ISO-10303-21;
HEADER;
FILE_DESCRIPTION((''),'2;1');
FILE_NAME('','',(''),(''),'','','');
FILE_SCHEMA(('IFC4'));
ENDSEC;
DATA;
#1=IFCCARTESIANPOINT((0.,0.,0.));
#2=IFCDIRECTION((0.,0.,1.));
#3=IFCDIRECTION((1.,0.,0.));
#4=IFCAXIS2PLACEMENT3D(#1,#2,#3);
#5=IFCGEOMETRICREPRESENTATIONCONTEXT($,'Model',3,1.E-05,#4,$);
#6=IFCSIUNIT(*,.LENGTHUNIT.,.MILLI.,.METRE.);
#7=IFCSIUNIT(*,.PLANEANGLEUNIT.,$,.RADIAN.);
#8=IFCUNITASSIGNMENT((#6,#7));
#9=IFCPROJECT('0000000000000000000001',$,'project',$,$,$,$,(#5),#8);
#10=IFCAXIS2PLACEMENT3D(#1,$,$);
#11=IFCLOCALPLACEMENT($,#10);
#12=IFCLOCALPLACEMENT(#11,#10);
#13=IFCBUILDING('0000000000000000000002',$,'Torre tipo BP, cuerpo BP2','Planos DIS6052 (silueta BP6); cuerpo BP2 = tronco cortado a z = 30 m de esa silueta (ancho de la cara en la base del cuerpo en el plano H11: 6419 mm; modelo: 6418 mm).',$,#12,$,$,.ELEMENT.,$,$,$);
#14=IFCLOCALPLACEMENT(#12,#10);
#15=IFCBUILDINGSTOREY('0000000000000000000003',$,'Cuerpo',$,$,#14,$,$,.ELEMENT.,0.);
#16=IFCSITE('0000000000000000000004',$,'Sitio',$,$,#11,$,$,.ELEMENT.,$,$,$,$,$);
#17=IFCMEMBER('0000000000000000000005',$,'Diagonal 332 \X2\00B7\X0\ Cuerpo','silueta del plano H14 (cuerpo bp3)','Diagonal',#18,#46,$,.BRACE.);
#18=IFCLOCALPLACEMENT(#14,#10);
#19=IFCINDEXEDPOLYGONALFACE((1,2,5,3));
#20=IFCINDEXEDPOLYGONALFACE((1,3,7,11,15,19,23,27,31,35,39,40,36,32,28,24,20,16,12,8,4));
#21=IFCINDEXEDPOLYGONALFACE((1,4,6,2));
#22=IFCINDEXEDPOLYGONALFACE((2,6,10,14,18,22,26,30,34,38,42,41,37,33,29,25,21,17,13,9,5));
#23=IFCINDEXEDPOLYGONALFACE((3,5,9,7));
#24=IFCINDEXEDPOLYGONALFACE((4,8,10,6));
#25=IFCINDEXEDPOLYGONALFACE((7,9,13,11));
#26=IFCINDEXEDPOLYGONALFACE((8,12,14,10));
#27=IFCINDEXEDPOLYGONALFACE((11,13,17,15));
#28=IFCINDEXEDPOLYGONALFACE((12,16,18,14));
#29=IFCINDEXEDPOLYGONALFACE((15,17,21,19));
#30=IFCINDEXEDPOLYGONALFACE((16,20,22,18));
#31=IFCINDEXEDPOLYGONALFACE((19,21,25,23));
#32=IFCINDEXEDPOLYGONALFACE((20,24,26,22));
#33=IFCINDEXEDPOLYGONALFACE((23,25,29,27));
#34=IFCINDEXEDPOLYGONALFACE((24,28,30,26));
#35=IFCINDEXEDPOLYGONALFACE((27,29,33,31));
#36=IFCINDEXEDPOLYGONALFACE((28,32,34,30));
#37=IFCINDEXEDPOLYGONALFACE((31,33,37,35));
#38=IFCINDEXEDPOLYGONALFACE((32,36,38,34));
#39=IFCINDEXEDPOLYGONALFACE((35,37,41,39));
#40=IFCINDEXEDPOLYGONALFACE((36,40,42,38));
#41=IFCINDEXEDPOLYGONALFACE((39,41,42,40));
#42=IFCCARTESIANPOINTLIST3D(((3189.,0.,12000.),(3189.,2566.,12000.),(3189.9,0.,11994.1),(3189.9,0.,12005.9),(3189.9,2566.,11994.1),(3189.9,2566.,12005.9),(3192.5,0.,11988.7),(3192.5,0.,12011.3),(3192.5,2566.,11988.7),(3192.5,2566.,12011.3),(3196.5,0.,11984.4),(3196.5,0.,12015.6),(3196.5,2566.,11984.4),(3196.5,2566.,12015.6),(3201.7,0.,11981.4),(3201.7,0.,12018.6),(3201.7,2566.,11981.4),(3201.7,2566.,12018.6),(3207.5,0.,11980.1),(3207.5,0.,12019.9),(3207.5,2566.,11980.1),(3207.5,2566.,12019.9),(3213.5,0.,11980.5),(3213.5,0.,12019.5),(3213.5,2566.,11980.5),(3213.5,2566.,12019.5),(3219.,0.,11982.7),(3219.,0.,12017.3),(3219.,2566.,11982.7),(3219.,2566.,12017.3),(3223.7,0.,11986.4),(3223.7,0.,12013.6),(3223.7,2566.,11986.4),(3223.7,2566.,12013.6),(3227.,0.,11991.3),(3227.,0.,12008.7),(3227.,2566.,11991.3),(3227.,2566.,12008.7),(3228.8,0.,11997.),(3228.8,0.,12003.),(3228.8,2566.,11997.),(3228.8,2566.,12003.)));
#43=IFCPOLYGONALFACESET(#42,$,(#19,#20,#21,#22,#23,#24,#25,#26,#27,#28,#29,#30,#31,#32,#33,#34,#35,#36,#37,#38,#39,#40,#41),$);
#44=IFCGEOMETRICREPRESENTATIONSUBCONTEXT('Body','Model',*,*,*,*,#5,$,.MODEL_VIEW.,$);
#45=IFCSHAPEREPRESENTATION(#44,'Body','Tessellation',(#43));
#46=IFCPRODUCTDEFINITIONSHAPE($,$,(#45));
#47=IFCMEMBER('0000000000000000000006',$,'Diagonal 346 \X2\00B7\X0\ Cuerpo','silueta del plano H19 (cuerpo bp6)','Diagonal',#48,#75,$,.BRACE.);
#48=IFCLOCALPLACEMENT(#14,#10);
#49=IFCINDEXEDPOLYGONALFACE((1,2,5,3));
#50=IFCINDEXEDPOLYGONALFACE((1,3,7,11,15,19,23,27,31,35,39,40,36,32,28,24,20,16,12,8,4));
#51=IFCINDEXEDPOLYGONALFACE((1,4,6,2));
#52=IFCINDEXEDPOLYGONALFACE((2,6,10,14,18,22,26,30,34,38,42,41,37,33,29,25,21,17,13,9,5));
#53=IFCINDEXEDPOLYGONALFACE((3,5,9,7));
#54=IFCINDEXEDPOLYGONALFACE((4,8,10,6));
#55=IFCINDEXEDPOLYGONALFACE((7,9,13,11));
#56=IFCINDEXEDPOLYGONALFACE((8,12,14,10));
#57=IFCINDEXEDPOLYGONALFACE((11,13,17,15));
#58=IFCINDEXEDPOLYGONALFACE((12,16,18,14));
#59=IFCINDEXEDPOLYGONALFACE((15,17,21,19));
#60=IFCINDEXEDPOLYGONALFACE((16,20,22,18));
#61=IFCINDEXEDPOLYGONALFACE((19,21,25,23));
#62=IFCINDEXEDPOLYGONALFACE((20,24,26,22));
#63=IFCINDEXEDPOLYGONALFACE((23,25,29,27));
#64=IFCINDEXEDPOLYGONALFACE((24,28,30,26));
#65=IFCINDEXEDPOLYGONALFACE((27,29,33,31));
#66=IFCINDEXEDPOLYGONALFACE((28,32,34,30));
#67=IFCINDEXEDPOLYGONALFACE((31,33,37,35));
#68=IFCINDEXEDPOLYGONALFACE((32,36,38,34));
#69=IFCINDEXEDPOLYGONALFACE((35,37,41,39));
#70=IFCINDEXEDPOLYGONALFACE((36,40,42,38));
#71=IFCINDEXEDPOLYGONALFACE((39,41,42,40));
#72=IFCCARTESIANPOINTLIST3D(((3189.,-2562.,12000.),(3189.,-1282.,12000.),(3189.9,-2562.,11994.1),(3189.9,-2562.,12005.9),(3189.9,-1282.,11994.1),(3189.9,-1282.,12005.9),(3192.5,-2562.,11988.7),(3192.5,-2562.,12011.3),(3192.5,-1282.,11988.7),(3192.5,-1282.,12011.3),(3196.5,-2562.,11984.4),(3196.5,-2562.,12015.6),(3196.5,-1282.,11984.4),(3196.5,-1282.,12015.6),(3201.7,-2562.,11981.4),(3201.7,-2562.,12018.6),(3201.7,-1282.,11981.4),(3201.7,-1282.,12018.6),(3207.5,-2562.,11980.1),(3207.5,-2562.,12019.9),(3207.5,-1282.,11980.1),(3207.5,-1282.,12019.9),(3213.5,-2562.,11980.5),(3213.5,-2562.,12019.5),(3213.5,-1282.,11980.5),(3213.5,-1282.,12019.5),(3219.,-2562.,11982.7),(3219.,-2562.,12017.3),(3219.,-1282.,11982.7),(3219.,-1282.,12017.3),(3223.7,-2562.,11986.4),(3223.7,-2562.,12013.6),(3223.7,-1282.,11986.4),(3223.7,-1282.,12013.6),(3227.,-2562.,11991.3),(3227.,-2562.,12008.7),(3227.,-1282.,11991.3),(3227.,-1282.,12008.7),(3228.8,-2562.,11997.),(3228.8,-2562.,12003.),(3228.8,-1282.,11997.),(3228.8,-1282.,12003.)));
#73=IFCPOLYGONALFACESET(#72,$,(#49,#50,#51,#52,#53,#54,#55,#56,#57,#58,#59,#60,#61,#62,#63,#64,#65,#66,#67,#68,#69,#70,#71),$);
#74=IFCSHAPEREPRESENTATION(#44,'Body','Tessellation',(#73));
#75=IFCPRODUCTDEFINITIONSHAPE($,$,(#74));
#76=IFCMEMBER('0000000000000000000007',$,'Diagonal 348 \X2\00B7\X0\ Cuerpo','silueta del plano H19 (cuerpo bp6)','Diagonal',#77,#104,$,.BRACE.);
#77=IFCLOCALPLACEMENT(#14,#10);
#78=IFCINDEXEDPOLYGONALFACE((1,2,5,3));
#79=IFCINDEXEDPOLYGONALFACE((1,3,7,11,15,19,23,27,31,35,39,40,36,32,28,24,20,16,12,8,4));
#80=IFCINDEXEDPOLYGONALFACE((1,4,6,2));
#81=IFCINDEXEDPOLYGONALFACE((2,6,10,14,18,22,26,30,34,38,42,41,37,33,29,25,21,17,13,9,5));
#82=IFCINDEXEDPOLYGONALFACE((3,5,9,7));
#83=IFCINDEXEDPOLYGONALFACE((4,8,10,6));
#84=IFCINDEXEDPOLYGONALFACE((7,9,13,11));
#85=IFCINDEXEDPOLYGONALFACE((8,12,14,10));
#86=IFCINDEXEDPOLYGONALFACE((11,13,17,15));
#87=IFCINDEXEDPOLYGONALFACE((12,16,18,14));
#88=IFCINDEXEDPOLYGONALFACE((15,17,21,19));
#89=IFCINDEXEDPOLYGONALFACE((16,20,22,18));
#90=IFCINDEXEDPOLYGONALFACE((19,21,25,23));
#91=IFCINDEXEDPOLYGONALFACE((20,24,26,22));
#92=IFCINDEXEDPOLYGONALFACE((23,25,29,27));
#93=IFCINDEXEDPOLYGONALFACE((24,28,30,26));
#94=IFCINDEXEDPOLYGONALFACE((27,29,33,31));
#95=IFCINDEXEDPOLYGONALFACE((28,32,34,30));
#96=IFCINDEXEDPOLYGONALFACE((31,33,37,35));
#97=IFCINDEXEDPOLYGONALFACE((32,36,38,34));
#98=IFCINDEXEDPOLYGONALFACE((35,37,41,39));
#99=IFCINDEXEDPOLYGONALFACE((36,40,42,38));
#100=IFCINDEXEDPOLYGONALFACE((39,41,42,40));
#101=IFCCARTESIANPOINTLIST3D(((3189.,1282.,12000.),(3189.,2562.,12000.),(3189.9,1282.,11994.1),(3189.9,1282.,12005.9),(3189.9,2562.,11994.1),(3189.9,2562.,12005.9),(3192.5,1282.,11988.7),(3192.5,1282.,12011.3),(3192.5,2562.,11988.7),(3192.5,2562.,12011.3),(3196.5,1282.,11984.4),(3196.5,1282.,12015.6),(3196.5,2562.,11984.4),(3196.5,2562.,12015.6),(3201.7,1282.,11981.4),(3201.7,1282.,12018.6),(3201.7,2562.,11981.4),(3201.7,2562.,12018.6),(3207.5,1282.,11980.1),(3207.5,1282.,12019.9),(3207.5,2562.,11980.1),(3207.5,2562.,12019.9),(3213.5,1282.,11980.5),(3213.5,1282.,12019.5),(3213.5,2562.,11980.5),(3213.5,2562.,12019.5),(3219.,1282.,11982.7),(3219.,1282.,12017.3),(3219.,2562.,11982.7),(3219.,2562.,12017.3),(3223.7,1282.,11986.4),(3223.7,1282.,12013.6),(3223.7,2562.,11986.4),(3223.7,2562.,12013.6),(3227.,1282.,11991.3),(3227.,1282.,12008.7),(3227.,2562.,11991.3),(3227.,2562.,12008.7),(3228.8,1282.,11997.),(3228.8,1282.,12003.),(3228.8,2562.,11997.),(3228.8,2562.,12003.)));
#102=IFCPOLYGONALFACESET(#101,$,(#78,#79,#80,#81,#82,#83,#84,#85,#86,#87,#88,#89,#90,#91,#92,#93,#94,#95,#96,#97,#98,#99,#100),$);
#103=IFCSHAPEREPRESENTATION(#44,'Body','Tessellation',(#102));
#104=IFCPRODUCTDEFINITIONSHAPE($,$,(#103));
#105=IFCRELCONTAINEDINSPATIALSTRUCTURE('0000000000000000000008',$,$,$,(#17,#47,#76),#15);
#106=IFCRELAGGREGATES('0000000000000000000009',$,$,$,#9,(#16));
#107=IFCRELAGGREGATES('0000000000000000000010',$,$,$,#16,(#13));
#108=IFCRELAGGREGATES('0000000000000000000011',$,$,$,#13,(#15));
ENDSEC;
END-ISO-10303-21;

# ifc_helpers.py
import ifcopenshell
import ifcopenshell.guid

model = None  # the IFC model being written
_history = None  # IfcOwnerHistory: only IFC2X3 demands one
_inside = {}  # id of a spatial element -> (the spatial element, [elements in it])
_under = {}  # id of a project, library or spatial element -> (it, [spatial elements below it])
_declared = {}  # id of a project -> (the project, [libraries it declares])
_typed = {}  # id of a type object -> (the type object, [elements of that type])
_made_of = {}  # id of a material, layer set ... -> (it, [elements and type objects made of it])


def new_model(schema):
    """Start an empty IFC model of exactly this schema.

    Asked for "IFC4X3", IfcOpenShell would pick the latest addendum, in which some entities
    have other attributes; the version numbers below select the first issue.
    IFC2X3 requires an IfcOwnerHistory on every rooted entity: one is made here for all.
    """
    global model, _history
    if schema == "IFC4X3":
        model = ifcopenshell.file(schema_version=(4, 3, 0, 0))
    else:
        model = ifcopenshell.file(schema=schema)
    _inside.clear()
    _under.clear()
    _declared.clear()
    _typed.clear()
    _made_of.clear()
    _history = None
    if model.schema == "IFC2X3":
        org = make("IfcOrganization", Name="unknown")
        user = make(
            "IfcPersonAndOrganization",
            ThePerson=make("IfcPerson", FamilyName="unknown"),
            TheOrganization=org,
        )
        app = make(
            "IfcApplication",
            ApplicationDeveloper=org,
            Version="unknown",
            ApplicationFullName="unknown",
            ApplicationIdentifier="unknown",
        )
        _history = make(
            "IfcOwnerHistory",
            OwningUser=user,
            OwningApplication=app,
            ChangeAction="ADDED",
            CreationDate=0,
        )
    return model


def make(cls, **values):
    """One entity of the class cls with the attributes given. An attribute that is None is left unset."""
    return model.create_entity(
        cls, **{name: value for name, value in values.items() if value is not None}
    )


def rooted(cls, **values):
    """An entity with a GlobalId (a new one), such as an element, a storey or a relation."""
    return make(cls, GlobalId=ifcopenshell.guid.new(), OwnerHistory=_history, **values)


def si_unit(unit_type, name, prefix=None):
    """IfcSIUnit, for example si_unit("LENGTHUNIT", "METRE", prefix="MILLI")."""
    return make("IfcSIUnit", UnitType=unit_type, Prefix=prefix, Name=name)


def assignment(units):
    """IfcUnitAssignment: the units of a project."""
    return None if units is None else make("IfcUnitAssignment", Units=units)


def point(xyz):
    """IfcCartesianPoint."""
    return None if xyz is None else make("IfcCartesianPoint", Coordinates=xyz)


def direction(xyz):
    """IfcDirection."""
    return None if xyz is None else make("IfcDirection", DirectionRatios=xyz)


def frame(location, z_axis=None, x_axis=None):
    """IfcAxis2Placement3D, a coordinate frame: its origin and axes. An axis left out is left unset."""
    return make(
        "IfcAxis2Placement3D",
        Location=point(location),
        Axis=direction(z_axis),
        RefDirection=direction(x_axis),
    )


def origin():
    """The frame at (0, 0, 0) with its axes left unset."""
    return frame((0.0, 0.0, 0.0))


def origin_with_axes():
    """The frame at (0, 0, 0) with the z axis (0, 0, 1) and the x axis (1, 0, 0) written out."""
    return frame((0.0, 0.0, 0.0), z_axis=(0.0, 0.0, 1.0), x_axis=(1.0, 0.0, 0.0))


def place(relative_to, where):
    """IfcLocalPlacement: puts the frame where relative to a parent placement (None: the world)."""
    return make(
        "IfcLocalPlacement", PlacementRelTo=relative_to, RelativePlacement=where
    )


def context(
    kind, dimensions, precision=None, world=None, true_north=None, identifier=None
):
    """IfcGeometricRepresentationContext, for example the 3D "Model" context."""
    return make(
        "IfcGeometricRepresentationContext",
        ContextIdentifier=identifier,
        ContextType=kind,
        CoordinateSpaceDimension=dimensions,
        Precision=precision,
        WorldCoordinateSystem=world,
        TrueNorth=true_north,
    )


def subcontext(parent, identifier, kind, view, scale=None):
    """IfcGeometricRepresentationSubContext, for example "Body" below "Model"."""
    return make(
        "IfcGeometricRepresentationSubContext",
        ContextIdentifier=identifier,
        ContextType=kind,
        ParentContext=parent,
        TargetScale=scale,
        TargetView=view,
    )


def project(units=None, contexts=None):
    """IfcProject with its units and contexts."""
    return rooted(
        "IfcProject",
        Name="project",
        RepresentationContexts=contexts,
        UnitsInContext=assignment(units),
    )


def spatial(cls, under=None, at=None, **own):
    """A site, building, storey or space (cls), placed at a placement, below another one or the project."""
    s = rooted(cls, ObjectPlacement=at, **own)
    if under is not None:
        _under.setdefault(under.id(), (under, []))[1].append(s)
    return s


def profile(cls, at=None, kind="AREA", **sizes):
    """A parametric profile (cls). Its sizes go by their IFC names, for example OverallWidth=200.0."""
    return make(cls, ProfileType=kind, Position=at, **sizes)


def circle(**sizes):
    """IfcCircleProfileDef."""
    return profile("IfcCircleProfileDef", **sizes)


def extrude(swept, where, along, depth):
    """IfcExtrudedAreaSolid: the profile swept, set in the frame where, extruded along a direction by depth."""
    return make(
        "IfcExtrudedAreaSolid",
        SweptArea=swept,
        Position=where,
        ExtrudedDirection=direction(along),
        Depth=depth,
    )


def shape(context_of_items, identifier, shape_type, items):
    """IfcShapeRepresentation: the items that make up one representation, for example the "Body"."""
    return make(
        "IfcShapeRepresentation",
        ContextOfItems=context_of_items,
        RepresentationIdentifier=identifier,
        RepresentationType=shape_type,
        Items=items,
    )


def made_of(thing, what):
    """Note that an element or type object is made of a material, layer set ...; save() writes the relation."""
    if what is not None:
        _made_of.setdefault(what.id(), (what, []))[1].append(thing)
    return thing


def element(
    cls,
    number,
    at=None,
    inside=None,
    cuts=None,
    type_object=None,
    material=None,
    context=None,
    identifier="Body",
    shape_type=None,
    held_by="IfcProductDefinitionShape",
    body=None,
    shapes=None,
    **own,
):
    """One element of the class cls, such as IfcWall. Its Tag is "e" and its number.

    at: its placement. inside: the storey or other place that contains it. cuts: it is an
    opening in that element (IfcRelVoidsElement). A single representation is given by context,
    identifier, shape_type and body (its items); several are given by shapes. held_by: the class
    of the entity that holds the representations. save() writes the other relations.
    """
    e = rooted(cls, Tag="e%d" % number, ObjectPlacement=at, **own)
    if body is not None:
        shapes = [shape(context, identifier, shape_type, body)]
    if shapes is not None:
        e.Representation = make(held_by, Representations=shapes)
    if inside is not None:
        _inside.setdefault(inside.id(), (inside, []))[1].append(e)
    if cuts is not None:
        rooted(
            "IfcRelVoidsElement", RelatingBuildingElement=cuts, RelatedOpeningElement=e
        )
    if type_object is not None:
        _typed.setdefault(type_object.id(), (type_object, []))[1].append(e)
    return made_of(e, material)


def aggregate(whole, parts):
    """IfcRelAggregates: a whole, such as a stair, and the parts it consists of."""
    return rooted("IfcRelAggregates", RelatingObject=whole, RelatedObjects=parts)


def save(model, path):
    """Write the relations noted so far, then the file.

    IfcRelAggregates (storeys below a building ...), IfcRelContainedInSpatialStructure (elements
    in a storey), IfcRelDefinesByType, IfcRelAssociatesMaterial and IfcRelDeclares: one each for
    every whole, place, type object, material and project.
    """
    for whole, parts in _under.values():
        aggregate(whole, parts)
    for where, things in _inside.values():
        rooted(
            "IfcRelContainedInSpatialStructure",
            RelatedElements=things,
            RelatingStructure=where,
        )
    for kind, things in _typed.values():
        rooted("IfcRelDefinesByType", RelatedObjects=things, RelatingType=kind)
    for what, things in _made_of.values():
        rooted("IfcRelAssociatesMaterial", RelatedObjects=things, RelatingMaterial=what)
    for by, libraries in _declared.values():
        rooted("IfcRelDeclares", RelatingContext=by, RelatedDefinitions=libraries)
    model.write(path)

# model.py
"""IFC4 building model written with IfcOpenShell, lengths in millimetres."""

from ifc_helpers import new_model, si_unit, frame, origin, origin_with_axes, place, context, subcontext, project, spatial, circle, extrude, element, save


model = new_model("IFC4")

# Units and contexts
model_context = context("Model", 3, precision=1e-05, world=origin_with_axes())
body_context = subcontext(model_context, "Body", "Model", "MODEL_VIEW")
ifc_project = project(units=[si_unit("LENGTHUNIT", "METRE", prefix="MILLI"), si_unit("PLANEANGLEUNIT", "RADIAN")], contexts=[model_context])

# Site, building, storey
site_placement = place(None, origin())
site = spatial("IfcSite", under=ifc_project, at=site_placement, Name="Sitio", CompositionType="ELEMENT")
building_placement = place(site_placement, origin())
building = spatial("IfcBuilding", under=site, at=building_placement, Name="Torre tipo BP, cuerpo BP2", Description="Planos DIS6052 (silueta BP6); cuerpo BP2 = tronco cortado a z = 30 m de esa silueta (ancho de la cara en la base del cuerpo en el plano H11: 6419 mm; modelo: 6418 mm).", CompositionType="ELEMENT")
storey_placement = place(building_placement, origin())
storey = spatial("IfcBuildingStorey", under=building, at=storey_placement, Name="Cuerpo", CompositionType="ELEMENT", Elevation=0.0)

# Members
for number, where, z_axis, x_axis, name in (
    (1, (3209.0, 2566.0, 12000.0), (0.0, -1.0, 0.0), (-1.0, 0.0, 0.0), "Diagonal 332 · Cuerpo"),
):
    element("IfcMember", number, at=place(storey_placement, frame(where, z_axis=z_axis, x_axis=x_axis)), inside=storey, Name=name, Description="silueta del plano H14 (cuerpo bp3)", ObjectType="Diagonal", PredefinedType="BRACE", context=body_context, shape_type="SweptSolid", body=[
        extrude(circle(Radius=20.0), None, (0.0, 0.0, 1.0), 2566.0),
    ])
for number, where, z_axis, x_axis, name in (
    (2, (3209.0, -2562.0, 12000.0), (0.0, 1.0, 0.0), (-1.0, 0.0, 0.0), "Diagonal 346 · Cuerpo"),
    (3, (3209.0, 2562.0, 12000.0), (0.0, -1.0, 0.0), (-1.0, 0.0, 0.0), "Diagonal 348 · Cuerpo"),
):
    element("IfcMember", number, at=place(storey_placement, frame(where, z_axis=z_axis, x_axis=x_axis)), inside=storey, Name=name, Description="silueta del plano H19 (cuerpo bp6)", ObjectType="Diagonal", PredefinedType="BRACE", context=body_context, shape_type="SweptSolid", body=[
        extrude(circle(Radius=20.0), None, (0.0, 0.0, 1.0), 1280.0),
    ])

save(model, "model.ifc")
